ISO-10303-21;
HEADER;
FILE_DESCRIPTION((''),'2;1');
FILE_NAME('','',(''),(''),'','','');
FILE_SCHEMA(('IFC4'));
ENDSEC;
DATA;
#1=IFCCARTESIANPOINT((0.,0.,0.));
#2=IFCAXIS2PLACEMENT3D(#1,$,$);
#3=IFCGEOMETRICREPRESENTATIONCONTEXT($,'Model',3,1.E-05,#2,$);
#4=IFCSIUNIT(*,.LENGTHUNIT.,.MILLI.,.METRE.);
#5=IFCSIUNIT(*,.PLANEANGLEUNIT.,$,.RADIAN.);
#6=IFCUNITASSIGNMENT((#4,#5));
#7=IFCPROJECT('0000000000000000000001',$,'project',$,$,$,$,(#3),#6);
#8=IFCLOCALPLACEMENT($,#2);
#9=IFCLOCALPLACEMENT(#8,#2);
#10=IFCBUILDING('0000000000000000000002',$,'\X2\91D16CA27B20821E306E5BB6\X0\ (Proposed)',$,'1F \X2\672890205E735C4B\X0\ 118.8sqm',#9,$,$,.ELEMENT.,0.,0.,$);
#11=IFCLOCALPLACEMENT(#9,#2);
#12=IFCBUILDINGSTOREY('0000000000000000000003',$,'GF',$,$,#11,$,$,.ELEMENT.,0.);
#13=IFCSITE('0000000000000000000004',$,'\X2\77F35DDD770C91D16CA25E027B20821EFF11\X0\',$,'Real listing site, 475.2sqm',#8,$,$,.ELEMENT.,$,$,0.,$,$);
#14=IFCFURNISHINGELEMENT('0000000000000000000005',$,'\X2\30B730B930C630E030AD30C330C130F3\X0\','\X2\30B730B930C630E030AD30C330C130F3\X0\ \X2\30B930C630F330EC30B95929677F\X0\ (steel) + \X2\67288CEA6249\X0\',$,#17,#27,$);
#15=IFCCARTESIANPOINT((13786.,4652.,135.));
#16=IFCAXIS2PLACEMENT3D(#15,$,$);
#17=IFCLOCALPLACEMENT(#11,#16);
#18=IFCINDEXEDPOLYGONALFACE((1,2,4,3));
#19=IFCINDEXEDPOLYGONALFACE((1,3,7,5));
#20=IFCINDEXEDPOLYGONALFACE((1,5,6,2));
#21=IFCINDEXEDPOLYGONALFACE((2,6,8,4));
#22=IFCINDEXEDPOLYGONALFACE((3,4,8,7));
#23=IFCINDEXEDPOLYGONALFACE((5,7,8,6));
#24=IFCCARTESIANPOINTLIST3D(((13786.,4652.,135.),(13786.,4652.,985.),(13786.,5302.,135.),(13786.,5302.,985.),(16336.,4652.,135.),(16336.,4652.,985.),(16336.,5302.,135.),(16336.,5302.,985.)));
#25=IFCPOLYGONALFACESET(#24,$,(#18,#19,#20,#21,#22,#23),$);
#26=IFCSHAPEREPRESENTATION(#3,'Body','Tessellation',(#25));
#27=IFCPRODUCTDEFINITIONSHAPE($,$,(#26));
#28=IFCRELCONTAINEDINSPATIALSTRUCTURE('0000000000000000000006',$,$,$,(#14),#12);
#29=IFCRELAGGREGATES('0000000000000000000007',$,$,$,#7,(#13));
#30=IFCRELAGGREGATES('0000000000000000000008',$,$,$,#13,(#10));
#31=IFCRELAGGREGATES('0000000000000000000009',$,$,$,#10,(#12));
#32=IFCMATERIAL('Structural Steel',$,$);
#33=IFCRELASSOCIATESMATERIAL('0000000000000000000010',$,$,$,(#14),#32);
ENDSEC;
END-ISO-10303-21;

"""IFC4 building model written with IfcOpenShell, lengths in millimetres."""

from ifc_helpers import new_model, si_unit, frame, frame_2d, origin, place, context, project, spatial, rectangle, extrude, material, element, save


model = new_model("IFC4")

# Units and contexts
model_context = context("Model", 3, precision=1e-05, world=origin())
ifc_project = project(units=[si_unit("LENGTHUNIT", "METRE", prefix="MILLI"), si_unit("PLANEANGLEUNIT", "RADIAN")], contexts=[model_context])

# Site, building, storey
site_placement = place(None, origin())
site = spatial("IfcSite", under=ifc_project, at=site_placement, Name="石川県金沢市笠舞１", ObjectType="Real listing site, 475.2sqm", CompositionType="ELEMENT", RefElevation=0.0)
building_placement = place(site_placement, origin())
building = spatial("IfcBuilding", under=site, at=building_placement, Name="金沢笠舞の家 (Proposed)", ObjectType="1F 木造平屋 118.8sqm", CompositionType="ELEMENT", ElevationOfRefHeight=0.0, ElevationOfTerrain=0.0)
storey_placement = place(building_placement, origin())
storey = spatial("IfcBuildingStorey", under=building, at=storey_placement, Name="GF", CompositionType="ELEMENT", Elevation=0.0)

# Shared definitions
ifc_material_1 = material(Name="Structural Steel")

# Furnishing element
furnishing_1_placement = place(storey_placement, frame((13786.0, 4652.0, 135.0)))
element("IfcFurnishingElement", 1, at=furnishing_1_placement, inside=storey, material=ifc_material_1, Name="システムキッチン", Description="システムキッチン ステンレス天板 (steel) + 木質扉", context=model_context, shape_type="SweptSolid", body=[
    extrude(rectangle(XDim=2550.0, YDim=650.0, at=frame_2d((1275.0, 325.0))), frame((13786.0, 4652.0, 135.0)), (0.0, 0.0, 1.0), 850.0),
])

save(model, "model.ifc")
